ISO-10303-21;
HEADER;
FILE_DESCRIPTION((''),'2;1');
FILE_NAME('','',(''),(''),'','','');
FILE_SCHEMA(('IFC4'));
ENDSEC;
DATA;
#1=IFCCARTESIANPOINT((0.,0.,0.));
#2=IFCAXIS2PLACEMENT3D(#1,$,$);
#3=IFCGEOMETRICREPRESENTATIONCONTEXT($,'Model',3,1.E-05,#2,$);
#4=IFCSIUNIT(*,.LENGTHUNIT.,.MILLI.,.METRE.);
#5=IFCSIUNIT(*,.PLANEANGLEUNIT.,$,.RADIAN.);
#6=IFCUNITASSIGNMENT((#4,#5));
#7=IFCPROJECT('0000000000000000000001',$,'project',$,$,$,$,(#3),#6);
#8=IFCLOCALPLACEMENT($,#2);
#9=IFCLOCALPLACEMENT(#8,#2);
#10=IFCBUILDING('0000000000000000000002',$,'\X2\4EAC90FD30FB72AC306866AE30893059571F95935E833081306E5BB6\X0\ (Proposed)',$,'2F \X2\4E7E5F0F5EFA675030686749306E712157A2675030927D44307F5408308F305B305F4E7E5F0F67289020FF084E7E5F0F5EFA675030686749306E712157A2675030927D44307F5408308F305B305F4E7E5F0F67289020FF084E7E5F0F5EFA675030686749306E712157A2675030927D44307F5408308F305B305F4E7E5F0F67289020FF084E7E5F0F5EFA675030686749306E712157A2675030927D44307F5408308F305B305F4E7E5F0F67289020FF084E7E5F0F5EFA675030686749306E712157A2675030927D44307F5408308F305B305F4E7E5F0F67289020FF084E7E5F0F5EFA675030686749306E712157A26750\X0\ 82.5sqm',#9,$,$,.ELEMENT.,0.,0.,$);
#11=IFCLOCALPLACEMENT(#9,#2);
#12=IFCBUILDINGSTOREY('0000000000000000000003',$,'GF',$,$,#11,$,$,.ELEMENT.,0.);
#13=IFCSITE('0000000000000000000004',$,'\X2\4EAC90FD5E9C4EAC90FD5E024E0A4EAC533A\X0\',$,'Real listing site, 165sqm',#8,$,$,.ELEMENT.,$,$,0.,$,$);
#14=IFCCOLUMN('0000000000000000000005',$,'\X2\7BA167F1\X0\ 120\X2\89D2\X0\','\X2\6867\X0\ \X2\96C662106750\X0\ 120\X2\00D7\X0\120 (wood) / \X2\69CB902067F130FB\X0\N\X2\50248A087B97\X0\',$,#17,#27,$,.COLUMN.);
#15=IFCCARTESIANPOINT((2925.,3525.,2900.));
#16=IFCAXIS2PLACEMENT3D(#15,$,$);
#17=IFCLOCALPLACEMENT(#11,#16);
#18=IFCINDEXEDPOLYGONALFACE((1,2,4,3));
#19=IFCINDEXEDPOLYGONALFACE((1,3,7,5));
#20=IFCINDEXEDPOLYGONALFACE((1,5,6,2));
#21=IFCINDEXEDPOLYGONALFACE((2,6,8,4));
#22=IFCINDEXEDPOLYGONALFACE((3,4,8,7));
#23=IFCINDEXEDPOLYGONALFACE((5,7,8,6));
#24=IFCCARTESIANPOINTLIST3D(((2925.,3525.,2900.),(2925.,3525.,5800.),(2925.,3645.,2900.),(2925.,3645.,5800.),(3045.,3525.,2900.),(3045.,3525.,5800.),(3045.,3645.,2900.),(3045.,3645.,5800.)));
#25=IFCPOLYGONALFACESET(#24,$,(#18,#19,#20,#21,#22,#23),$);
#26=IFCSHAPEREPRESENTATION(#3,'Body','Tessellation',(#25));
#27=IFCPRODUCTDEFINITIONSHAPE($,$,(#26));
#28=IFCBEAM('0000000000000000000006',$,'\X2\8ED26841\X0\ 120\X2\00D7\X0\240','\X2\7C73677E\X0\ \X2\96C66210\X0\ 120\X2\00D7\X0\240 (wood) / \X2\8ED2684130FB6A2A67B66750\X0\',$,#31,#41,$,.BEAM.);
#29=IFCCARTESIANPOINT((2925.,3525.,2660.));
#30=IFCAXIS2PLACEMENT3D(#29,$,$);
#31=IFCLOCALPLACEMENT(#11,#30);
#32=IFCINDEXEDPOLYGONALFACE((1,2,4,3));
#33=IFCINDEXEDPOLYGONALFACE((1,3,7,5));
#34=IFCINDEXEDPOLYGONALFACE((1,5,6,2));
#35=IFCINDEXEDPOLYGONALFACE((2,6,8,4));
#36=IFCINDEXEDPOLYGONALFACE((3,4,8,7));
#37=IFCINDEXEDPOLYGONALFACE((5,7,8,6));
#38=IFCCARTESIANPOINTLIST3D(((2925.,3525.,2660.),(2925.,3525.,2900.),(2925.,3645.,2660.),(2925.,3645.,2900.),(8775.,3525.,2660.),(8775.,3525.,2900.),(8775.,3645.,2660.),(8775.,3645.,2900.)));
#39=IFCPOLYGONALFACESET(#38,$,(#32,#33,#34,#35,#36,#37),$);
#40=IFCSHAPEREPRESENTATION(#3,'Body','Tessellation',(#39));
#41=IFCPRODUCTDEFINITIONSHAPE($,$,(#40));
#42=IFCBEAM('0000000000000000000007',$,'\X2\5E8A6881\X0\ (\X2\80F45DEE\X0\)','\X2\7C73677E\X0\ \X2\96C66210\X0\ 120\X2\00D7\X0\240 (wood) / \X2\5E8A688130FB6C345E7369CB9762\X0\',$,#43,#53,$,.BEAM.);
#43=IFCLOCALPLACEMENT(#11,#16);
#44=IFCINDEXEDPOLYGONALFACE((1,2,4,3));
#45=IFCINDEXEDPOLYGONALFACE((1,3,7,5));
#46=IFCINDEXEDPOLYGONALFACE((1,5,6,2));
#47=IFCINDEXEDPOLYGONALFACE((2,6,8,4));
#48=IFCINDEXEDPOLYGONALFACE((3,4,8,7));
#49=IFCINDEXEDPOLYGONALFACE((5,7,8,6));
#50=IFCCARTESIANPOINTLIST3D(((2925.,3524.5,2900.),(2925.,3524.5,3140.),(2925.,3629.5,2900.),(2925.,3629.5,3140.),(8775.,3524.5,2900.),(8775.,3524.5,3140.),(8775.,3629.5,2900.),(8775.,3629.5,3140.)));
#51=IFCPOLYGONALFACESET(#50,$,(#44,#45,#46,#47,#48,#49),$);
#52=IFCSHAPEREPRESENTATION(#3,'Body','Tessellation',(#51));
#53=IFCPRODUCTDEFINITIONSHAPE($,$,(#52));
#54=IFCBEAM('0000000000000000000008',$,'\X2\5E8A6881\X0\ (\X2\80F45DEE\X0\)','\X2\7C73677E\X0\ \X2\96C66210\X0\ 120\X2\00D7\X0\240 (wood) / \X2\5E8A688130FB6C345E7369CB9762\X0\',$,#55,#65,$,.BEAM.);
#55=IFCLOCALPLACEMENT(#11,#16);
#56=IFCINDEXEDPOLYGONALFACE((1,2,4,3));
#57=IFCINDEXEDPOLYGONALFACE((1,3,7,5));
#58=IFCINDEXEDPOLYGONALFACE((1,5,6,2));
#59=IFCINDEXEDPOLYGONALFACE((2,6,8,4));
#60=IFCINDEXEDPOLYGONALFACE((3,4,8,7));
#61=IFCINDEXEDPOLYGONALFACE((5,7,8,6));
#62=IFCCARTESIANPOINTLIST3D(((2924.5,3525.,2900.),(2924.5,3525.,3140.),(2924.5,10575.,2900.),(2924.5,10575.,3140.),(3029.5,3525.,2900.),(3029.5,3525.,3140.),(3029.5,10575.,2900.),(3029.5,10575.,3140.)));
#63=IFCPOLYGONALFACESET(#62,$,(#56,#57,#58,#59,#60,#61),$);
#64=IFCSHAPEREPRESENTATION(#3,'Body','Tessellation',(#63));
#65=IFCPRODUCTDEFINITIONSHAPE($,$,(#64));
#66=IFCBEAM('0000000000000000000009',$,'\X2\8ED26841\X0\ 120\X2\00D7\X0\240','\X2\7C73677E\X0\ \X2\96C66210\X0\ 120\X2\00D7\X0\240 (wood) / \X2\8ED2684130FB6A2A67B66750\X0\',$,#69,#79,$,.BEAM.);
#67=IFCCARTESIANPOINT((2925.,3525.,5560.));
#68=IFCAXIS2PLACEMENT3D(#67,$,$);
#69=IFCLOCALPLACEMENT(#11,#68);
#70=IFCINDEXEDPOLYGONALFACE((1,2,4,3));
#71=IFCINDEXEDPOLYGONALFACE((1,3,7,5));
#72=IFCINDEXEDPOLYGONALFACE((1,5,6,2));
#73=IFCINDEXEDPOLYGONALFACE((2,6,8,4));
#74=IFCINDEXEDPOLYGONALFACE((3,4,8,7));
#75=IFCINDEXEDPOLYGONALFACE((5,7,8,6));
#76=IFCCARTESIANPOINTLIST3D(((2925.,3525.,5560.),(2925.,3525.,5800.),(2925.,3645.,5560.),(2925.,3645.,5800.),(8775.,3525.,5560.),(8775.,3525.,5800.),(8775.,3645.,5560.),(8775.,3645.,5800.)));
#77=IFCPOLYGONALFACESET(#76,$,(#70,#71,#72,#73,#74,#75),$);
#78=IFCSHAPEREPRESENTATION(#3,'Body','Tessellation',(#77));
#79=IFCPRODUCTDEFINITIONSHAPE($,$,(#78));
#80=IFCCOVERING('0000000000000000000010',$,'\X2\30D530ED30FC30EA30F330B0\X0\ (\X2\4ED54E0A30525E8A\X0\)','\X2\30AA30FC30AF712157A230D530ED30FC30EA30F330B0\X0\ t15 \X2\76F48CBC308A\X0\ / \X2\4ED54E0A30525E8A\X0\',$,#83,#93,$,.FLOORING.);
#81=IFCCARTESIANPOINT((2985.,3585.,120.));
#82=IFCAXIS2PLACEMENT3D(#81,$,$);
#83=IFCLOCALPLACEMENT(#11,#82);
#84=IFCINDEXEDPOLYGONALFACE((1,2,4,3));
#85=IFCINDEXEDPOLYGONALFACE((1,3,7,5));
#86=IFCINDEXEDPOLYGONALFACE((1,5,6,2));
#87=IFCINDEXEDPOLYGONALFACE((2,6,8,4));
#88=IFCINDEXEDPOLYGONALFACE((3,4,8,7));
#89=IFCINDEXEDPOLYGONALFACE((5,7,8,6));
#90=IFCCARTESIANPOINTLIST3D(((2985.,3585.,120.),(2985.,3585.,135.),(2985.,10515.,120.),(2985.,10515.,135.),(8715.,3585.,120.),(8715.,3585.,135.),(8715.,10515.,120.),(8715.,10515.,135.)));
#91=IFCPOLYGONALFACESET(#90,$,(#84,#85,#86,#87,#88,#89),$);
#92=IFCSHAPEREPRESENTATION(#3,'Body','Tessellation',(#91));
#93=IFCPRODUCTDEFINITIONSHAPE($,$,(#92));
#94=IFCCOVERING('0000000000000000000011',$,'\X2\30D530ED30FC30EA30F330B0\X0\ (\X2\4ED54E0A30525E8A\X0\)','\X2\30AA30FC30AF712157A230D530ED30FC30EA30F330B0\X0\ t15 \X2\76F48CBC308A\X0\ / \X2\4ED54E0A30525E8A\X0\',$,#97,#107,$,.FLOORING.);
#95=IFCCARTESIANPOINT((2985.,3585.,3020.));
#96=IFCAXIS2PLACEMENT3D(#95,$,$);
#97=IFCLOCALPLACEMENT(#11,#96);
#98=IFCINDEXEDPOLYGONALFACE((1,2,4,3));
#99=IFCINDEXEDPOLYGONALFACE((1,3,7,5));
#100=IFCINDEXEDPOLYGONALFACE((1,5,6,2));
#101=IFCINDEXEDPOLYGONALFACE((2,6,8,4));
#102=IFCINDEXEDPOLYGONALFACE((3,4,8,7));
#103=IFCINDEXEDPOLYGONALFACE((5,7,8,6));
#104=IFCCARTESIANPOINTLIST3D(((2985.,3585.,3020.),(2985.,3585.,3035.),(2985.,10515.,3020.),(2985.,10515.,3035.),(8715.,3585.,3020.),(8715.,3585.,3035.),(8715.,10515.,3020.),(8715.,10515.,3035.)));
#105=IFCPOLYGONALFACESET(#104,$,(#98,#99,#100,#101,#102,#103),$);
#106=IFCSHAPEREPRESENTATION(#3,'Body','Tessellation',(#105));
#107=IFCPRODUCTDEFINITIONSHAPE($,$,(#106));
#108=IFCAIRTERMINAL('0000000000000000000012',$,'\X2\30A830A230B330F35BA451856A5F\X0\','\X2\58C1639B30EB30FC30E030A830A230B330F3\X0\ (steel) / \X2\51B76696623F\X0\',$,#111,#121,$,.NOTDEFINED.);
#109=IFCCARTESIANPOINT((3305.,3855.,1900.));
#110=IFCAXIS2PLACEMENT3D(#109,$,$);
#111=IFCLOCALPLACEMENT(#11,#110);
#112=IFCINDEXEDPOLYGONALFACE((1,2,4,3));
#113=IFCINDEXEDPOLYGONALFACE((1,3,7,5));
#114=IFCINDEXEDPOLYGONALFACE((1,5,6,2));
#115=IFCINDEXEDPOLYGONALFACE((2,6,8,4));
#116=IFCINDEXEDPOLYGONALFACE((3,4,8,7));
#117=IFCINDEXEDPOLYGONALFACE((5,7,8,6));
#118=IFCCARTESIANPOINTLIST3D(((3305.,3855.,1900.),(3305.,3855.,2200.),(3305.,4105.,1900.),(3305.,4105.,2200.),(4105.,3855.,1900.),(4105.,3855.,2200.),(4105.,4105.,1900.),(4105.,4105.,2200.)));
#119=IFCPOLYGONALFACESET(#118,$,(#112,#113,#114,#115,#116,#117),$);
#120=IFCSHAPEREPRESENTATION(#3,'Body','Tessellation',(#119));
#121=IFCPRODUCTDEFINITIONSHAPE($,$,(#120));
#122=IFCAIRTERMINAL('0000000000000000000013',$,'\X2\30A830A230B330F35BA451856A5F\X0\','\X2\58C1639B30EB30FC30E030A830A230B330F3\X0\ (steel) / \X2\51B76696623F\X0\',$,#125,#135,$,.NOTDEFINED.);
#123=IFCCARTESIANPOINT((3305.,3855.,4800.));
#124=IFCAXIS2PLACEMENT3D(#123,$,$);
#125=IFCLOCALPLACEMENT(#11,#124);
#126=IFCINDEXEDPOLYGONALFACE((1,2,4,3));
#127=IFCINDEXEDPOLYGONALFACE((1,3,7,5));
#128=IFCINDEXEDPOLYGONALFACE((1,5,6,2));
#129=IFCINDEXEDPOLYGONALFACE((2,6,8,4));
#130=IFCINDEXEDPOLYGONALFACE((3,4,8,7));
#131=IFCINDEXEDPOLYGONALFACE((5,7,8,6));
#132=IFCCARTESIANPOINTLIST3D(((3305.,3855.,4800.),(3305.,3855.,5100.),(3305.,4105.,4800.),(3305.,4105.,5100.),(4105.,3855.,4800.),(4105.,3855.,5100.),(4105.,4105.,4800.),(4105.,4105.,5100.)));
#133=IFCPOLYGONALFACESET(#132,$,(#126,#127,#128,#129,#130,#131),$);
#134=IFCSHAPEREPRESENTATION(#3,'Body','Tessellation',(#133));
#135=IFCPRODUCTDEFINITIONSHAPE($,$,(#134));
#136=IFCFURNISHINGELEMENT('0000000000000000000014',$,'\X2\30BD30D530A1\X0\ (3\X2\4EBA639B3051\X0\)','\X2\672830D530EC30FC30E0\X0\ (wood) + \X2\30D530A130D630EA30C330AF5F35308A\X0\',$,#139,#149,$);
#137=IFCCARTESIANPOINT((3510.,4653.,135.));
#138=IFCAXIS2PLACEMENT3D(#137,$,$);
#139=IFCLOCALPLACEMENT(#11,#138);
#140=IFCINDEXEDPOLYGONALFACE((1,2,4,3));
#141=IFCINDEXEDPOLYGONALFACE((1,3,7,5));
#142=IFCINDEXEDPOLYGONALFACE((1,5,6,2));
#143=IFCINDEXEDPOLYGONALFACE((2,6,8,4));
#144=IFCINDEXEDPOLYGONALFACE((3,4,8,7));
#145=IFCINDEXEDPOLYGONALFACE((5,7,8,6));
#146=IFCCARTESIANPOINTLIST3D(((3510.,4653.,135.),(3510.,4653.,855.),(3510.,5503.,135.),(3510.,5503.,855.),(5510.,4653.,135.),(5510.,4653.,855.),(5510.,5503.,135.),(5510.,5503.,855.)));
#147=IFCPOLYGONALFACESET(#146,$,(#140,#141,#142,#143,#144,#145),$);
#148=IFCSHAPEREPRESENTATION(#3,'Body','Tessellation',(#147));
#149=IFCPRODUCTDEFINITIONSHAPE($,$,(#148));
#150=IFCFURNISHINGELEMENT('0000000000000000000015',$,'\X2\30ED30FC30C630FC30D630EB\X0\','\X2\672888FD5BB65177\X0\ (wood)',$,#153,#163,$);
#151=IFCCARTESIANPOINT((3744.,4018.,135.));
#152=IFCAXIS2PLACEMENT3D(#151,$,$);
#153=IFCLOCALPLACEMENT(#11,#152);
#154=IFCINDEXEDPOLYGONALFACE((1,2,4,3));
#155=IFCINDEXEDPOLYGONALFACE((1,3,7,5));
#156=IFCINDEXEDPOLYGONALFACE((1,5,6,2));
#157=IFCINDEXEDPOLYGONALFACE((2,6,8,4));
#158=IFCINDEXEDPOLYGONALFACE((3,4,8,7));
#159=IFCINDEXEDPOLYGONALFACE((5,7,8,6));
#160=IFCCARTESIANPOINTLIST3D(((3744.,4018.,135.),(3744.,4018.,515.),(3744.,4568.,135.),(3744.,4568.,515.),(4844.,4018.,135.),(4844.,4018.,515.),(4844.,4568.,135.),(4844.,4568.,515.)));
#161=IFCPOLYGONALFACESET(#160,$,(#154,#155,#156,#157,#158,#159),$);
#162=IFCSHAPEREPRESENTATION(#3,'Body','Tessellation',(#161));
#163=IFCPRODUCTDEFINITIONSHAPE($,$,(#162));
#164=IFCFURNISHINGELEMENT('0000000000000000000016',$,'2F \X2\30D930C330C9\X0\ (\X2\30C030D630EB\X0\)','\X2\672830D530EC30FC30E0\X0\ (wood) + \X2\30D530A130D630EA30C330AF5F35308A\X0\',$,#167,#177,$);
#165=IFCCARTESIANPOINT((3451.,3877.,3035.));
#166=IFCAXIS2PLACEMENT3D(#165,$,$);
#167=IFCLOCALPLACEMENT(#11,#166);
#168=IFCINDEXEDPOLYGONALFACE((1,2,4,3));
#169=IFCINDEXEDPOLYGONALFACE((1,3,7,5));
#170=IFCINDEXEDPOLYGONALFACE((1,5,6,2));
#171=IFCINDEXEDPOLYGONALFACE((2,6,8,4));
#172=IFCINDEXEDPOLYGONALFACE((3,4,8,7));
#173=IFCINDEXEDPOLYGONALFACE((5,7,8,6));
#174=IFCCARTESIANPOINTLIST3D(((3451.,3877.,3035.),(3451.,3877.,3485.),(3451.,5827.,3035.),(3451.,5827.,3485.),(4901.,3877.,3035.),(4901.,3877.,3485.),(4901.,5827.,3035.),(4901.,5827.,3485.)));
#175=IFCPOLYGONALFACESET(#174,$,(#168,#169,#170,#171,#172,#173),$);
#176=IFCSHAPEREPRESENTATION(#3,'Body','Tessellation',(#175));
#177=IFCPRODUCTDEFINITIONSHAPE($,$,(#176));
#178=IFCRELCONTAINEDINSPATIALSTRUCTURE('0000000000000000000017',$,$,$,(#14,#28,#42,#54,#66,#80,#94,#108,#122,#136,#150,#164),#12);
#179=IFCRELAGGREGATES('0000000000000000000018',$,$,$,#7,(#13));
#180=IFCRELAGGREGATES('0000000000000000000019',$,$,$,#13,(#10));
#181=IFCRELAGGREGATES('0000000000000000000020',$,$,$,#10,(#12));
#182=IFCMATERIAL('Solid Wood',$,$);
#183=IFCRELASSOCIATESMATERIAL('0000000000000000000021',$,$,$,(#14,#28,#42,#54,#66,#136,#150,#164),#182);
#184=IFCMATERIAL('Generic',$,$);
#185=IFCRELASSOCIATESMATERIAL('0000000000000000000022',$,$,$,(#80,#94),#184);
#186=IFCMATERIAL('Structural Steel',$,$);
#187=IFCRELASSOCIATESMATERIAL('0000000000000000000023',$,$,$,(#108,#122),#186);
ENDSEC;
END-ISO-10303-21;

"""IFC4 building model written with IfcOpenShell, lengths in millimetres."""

from ifc_helpers import new_model, si_unit, frame, frame_2d, origin, place, context, project, spatial, rectangle, extrude, material, element, save


model = new_model("IFC4")

# Units and contexts
model_context = context("Model", 3, precision=1e-05, world=origin())
ifc_project = project(units=[si_unit("LENGTHUNIT", "METRE", prefix="MILLI"), si_unit("PLANEANGLEUNIT", "RADIAN")], contexts=[model_context])

# Site, building, storey
site_placement = place(None, origin())
site = spatial("IfcSite", under=ifc_project, at=site_placement, Name="京都府京都市上京区", ObjectType="Real listing site, 165sqm", CompositionType="ELEMENT", RefElevation=0.0)
building_placement = place(site_placement, origin())
building = spatial("IfcBuilding", under=site, at=building_placement, Name="京都・犬と暮らす土間広めの家 (Proposed)", ObjectType="2F 乾式建材と杉の無垢材を組み合わせた乾式木造（乾式建材と杉の無垢材を組み合わせた乾式木造（乾式建材と杉の無垢材を組み合わせた乾式木造（乾式建材と杉の無垢材を組み合わせた乾式木造（乾式建材と杉の無垢材を組み合わせた乾式木造（乾式建材と杉の無垢材 82.5sqm", CompositionType="ELEMENT", ElevationOfRefHeight=0.0, ElevationOfTerrain=0.0)
storey_placement = place(building_placement, origin())
storey = spatial("IfcBuildingStorey", under=building, at=storey_placement, Name="GF", CompositionType="ELEMENT", Elevation=0.0)

# Column
ifc_material_1 = material(Name="Solid Wood")
column_placement = place(storey_placement, frame((2925.0, 3525.0, 2900.0)))
element("IfcColumn", 1, at=column_placement, inside=storey, material=ifc_material_1, Name="管柱 120角", Description="桧 集成材 120×120 (wood) / 構造柱・N値計算", PredefinedType="COLUMN", context=model_context, shape_type="SweptSolid", body=[
    extrude(rectangle(XDim=120.0, YDim=120.0, at=frame_2d((60.0, 60.0))), frame((2925.0, 3525.0, 2900.0)), (0.0, 0.0, 1.0), 2900.0),
])

# Beams
beam_1_placement = place(storey_placement, frame((2925.0, 3525.0, 2660.0)))
element("IfcBeam", 2, at=beam_1_placement, inside=storey, material=ifc_material_1, Name="軒桁 120×240", Description="米松 集成 120×240 (wood) / 軒桁・横架材", PredefinedType="BEAM", context=model_context, shape_type="SweptSolid", body=[
    extrude(rectangle(XDim=5850.0, YDim=120.0, at=frame_2d((2925.0, 60.0))), frame((2925.0, 3525.0, 2660.0)), (0.0, 0.0, 1.0), 240.0),
])
beam_2_placement = place(storey_placement, frame((2925.0, 3525.0, 2900.0)))
element("IfcBeam", 3, at=beam_2_placement, inside=storey, material=ifc_material_1, Name="床梁 (胴差)", Description="米松 集成 120×240 (wood) / 床梁・水平構面", PredefinedType="BEAM", context=model_context, shape_type="SweptSolid", body=[
    extrude(rectangle(XDim=5850.0, YDim=105.0, at=frame_2d((2925.0, 52.0))), frame((2925.0, 3525.0, 2900.0)), (0.0, 0.0, 1.0), 240.0),
])
beam_3_placement = place(storey_placement, frame((2925.0, 3525.0, 2900.0)))
element("IfcBeam", 4, at=beam_3_placement, inside=storey, material=ifc_material_1, Name="床梁 (胴差)", Description="米松 集成 120×240 (wood) / 床梁・水平構面", PredefinedType="BEAM", context=model_context, shape_type="SweptSolid", body=[
    extrude(rectangle(XDim=105.0, YDim=7050.0, at=frame_2d((52.0, 3525.0))), frame((2925.0, 3525.0, 2900.0)), (0.0, 0.0, 1.0), 240.0),
])
beam_4_placement = place(storey_placement, frame((2925.0, 3525.0, 5560.0)))
element("IfcBeam", 5, at=beam_4_placement, inside=storey, material=ifc_material_1, Name="軒桁 120×240", Description="米松 集成 120×240 (wood) / 軒桁・横架材", PredefinedType="BEAM", context=model_context, shape_type="SweptSolid", body=[
    extrude(rectangle(XDim=5850.0, YDim=120.0, at=frame_2d((2925.0, 60.0))), frame((2925.0, 3525.0, 5560.0)), (0.0, 0.0, 1.0), 240.0),
])

# Coverings
ifc_material_2 = material(Name="Generic")
covering_1_placement = place(storey_placement, frame((2985.0, 3585.0, 120.0)))
element("IfcCovering", 6, at=covering_1_placement, inside=storey, material=ifc_material_2, Name="フローリング (仕上げ床)", Description="オーク無垢フローリング t15 直貼り / 仕上げ床", PredefinedType="FLOORING", context=model_context, shape_type="SweptSolid", body=[
    extrude(rectangle(XDim=5730.0, YDim=6930.0, at=frame_2d((2865.0, 3465.0))), frame((2985.0, 3585.0, 120.0)), (0.0, 0.0, 1.0), 15.0),
])
covering_2_placement = place(storey_placement, frame((2985.0, 3585.0, 3020.0)))
element("IfcCovering", 7, at=covering_2_placement, inside=storey, material=ifc_material_2, Name="フローリング (仕上げ床)", Description="オーク無垢フローリング t15 直貼り / 仕上げ床", PredefinedType="FLOORING", context=model_context, shape_type="SweptSolid", body=[
    extrude(rectangle(XDim=5730.0, YDim=6930.0, at=frame_2d((2865.0, 3465.0))), frame((2985.0, 3585.0, 3020.0)), (0.0, 0.0, 1.0), 15.0),
])

# Air terminals
ifc_material_3 = material(Name="Structural Steel")
air_terminal_1_placement = place(storey_placement, frame((3305.0, 3855.0, 1900.0)))
element("IfcAirTerminal", 8, at=air_terminal_1_placement, inside=storey, material=ifc_material_3, Name="エアコン室内機", Description="壁掛ルームエアコン (steel) / 冷暖房", PredefinedType="NOTDEFINED", context=model_context, shape_type="SweptSolid", body=[
    extrude(rectangle(XDim=800.0, YDim=250.0, at=frame_2d((400.0, 125.0))), frame((3305.0, 3855.0, 1900.0)), (0.0, 0.0, 1.0), 300.0),
])
air_terminal_2_placement = place(storey_placement, frame((3305.0, 3855.0, 4800.0)))
element("IfcAirTerminal", 9, at=air_terminal_2_placement, inside=storey, material=ifc_material_3, Name="エアコン室内機", Description="壁掛ルームエアコン (steel) / 冷暖房", PredefinedType="NOTDEFINED", context=model_context, shape_type="SweptSolid", body=[
    extrude(rectangle(XDim=800.0, YDim=250.0, at=frame_2d((400.0, 125.0))), frame((3305.0, 3855.0, 4800.0)), (0.0, 0.0, 1.0), 300.0),
])

# Furnishing elements
furnishing_1_placement = place(storey_placement, frame((3510.0, 4653.0, 135.0)))
element("IfcFurnishingElement", 10, at=furnishing_1_placement, inside=storey, material=ifc_material_1, Name="ソファ (3人掛け)", Description="木フレーム (wood) + ファブリック張り", context=model_context, shape_type="SweptSolid", body=[
    extrude(rectangle(XDim=2000.0, YDim=850.0, at=frame_2d((1000.0, 425.0))), frame((3510.0, 4653.0, 135.0)), (0.0, 0.0, 1.0), 720.0),
])
furnishing_2_placement = place(storey_placement, frame((3744.0, 4018.0, 135.0)))
element("IfcFurnishingElement", 11, at=furnishing_2_placement, inside=storey, material=ifc_material_1, Name="ローテーブル", Description="木製家具 (wood)", context=model_context, shape_type="SweptSolid", body=[
    extrude(rectangle(XDim=1100.0, YDim=550.0, at=frame_2d((550.0, 275.0))), frame((3744.0, 4018.0, 135.0)), (0.0, 0.0, 1.0), 380.0),
])
furnishing_3_placement = place(storey_placement, frame((3451.0, 3877.0, 3035.0)))
element("IfcFurnishingElement", 12, at=furnishing_3_placement, inside=storey, material=ifc_material_1, Name="2F ベッド (ダブル)", Description="木フレーム (wood) + ファブリック張り", context=model_context, shape_type="SweptSolid", body=[
    extrude(rectangle(XDim=1450.0, YDim=1950.0, at=frame_2d((725.0, 975.0))), frame((3451.0, 3877.0, 3035.0)), (0.0, 0.0, 1.0), 450.0),
])

save(model, "model.ifc")
